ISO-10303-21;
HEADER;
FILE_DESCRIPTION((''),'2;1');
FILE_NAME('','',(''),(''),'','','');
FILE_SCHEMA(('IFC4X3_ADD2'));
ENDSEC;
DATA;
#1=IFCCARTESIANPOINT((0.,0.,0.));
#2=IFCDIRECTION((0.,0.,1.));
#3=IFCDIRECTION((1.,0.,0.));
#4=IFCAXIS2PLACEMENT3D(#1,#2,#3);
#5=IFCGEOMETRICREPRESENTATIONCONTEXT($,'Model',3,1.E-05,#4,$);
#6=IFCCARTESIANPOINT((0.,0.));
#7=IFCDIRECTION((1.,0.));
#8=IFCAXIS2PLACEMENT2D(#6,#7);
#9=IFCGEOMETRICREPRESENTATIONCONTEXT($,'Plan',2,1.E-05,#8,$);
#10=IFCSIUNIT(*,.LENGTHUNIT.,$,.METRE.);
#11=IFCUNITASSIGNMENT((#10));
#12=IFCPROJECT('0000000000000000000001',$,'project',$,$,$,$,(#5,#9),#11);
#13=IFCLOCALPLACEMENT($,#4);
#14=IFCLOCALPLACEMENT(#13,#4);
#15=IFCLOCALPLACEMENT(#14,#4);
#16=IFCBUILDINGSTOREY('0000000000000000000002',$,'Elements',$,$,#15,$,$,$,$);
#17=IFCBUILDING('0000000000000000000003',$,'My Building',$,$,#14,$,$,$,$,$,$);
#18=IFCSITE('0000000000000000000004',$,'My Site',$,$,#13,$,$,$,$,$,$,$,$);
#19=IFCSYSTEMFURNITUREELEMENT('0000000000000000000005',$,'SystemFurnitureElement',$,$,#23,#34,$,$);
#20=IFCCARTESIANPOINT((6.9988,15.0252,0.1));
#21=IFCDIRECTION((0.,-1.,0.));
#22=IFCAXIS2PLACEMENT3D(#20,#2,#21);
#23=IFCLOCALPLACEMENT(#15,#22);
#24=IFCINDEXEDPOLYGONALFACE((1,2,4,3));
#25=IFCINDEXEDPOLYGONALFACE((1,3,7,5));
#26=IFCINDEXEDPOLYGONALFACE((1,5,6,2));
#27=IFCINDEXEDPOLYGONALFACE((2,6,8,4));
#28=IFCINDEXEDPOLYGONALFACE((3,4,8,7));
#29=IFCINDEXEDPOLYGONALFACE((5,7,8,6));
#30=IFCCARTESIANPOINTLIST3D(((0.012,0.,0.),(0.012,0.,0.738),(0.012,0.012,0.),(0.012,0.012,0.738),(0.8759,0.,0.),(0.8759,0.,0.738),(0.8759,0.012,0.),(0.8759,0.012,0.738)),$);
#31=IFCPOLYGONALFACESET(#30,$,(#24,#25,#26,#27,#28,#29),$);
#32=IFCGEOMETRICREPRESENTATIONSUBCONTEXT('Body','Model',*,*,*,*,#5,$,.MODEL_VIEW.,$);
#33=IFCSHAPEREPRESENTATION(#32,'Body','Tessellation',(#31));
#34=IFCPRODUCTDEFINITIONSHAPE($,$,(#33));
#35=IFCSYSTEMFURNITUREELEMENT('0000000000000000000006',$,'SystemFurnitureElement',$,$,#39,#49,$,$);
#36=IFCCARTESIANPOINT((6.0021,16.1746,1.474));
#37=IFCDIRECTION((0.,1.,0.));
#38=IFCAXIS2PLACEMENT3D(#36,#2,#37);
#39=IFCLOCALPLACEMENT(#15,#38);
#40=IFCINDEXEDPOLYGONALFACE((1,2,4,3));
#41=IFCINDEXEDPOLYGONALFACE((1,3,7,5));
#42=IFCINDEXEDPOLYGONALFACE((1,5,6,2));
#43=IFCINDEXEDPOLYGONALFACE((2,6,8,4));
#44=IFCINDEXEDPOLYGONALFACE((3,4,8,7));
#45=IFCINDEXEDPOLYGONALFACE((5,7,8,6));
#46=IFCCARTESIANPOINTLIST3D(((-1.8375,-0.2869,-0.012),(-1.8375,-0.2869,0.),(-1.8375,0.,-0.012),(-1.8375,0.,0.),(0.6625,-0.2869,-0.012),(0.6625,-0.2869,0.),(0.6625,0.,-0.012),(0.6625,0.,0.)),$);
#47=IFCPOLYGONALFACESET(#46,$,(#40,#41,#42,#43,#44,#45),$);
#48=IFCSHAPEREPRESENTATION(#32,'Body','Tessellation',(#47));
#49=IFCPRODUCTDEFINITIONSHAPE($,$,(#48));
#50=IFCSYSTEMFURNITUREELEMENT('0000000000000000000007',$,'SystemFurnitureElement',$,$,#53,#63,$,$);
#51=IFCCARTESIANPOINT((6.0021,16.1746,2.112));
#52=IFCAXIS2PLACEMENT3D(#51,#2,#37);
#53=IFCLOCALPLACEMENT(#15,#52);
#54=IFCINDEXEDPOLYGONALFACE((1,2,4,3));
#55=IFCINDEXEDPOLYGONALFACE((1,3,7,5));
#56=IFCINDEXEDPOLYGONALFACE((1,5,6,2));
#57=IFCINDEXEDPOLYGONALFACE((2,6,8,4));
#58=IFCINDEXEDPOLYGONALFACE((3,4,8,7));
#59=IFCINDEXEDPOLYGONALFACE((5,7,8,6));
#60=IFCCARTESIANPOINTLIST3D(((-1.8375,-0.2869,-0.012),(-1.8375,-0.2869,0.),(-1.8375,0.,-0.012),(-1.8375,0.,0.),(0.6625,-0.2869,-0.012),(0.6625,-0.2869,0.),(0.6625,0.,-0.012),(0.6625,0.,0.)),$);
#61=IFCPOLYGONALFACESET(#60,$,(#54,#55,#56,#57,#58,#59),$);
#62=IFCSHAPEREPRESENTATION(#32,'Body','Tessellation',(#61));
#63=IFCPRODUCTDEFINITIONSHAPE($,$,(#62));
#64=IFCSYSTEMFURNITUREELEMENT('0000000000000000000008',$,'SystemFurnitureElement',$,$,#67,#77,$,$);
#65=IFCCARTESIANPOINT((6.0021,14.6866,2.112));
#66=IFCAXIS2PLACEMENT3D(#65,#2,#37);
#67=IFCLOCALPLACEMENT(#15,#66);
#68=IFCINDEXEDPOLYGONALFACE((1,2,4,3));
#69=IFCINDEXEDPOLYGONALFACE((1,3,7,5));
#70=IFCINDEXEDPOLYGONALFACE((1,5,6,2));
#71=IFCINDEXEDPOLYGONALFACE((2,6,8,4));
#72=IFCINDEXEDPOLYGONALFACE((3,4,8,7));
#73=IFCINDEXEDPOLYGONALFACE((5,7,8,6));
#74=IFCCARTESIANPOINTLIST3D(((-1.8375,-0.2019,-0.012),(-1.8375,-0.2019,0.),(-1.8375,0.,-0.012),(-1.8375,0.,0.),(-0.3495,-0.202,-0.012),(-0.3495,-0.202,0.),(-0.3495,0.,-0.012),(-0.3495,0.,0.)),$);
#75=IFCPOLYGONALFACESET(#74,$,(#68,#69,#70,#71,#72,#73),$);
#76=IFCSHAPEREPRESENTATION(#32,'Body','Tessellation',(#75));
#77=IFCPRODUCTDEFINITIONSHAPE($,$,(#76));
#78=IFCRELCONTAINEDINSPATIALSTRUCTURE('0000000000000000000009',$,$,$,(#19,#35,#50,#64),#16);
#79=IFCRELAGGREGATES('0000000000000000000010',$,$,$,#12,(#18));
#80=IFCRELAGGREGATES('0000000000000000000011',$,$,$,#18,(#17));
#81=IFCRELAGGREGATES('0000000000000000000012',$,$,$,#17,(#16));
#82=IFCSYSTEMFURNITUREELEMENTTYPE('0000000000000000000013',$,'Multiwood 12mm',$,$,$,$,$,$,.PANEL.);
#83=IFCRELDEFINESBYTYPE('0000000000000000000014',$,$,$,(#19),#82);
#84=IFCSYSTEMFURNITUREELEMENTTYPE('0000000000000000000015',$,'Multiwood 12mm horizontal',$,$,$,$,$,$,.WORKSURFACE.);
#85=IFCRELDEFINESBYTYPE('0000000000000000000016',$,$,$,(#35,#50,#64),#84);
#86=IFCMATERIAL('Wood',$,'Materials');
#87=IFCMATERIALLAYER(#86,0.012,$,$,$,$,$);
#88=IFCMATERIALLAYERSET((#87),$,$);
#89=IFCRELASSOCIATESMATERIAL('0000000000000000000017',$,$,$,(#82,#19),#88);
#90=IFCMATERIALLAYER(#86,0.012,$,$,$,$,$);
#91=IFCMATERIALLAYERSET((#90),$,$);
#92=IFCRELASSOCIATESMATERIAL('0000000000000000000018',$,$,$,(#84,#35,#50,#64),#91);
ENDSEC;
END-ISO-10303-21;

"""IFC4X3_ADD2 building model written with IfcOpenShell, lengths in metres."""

from ifc_helpers import new_model, si_unit, frame, origin_with_axes, origin_2d_with_axis, place, context, subcontext, project, spatial, line, indexed_curve, outline, extrude, material, layer, layer_set, layer_usage, type_object, element, save


model = new_model("IFC4X3_ADD2")

# Units and contexts
model_context = context("Model", 3, precision=1e-05, world=origin_with_axes())
plan_context = context("Plan", 2, precision=1e-05, world=origin_2d_with_axis())
body_context = subcontext(model_context, "Body", "Model", "MODEL_VIEW")
ifc_project = project(units=[si_unit("LENGTHUNIT", "METRE")], contexts=[model_context, plan_context])

# Site, building, storey
site_placement = place(None, origin_with_axes())
site = spatial("IfcSite", under=ifc_project, at=site_placement, Name="My Site")
building_placement = place(site_placement, origin_with_axes())
building = spatial("IfcBuilding", under=site, at=building_placement, Name="My Building")
storey_placement = place(building_placement, origin_with_axes())
storey = spatial("IfcBuildingStorey", under=building, at=storey_placement, Name="Elements")

# Shared definitions
ifc_material_1 = material(Name="Wood", Category="Materials")
ifc_layer_1 = layer(ifc_material_1, 0.012)
ifc_layer_set_1 = layer_set([ifc_layer_1])
system_furniture_element_type_1 = type_object("IfcSystemFurnitureElementType", Name="Multiwood 12mm", PredefinedType="PANEL", material=ifc_layer_set_1)

# System furniture elements
ifc_layer_usage_1 = layer_usage(ifc_layer_set_1, "AXIS2", "POSITIVE", 0.0)
system_furniture_element_1_placement = place(storey_placement, frame((6.9988, 15.0252, 0.1), z_axis=(0.0, 0.0, 1.0), x_axis=(0.0, -1.0, 0.0)))
element("IfcSystemFurnitureElement", 1, at=system_furniture_element_1_placement, inside=storey, type_object=system_furniture_element_type_1, material=ifc_layer_usage_1, Name="SystemFurnitureElement", context=body_context, shape_type="SweptSolid", body=[
    extrude(outline(indexed_curve([(0.012, 0.0), (0.012, 0.012), (0.8759, 0.012), (0.8759, 0.0)], segments=[line(1, 2, 3, 4, 1)])), origin_with_axes(), (0.0, 0.0, 1.0), 0.738),
])
ifc_layer_2 = layer(ifc_material_1, 0.012)
ifc_layer_set_2 = layer_set([ifc_layer_2])
ifc_layer_usage_2 = layer_usage(ifc_layer_set_2, "AXIS3", "POSITIVE", -0.012)
system_furniture_element_type_2 = type_object("IfcSystemFurnitureElementType", Name="Multiwood 12mm horizontal", PredefinedType="WORKSURFACE", material=ifc_layer_set_2)
system_furniture_element_2_placement = place(storey_placement, frame((6.0021, 16.1746, 1.474), z_axis=(0.0, 0.0, 1.0), x_axis=(0.0, 1.0, 0.0)))
element("IfcSystemFurnitureElement", 2, at=system_furniture_element_2_placement, inside=storey, type_object=system_furniture_element_type_2, material=ifc_layer_usage_2, Name="SystemFurnitureElement", context=body_context, shape_type="SweptSolid", body=[
    extrude(outline(indexed_curve([(-1.8375, -0.2869), (0.6625, -0.2869), (0.6625, 0.0), (-1.8375, 0.0), (-1.8375, -0.2869)])), frame((0.0, 0.0, -0.012), z_axis=(0.0, 0.0, 1.0), x_axis=(1.0, 0.0, 0.0)), (0.0, 0.0, 1.0), 0.012),
])
ifc_layer_usage_3 = layer_usage(ifc_layer_set_2, "AXIS3", "POSITIVE", -0.012)
system_furniture_element_3_placement = place(storey_placement, frame((6.0021, 16.1746, 2.112), z_axis=(0.0, 0.0, 1.0), x_axis=(0.0, 1.0, 0.0)))
element("IfcSystemFurnitureElement", 3, at=system_furniture_element_3_placement, inside=storey, type_object=system_furniture_element_type_2, material=ifc_layer_usage_3, Name="SystemFurnitureElement", context=body_context, shape_type="SweptSolid", body=[
    extrude(outline(indexed_curve([(-1.8375, -0.2869), (0.6625, -0.2869), (0.6625, 0.0), (-1.8375, 0.0), (-1.8375, -0.2869)])), frame((0.0, 0.0, -0.012), z_axis=(0.0, 0.0, 1.0), x_axis=(1.0, 0.0, 0.0)), (0.0, 0.0, 1.0), 0.012),
])
ifc_layer_usage_4 = layer_usage(ifc_layer_set_2, "AXIS3", "POSITIVE", -0.012)
system_furniture_element_4_placement = place(storey_placement, frame((6.0021, 14.6866, 2.112), z_axis=(0.0, 0.0, 1.0), x_axis=(0.0, 1.0, 0.0)))
element("IfcSystemFurnitureElement", 4, at=system_furniture_element_4_placement, inside=storey, type_object=system_furniture_element_type_2, material=ifc_layer_usage_4, Name="SystemFurnitureElement", context=body_context, shape_type="SweptSolid", body=[
    extrude(outline(indexed_curve([(-1.8375, -0.2019), (-0.3495, -0.202), (-0.3495, 0.0), (-1.8375, 0.0), (-1.8375, -0.2019)])), frame((0.0, 0.0, -0.012), z_axis=(0.0, 0.0, 1.0), x_axis=(1.0, 0.0, 0.0)), (0.0, 0.0, 1.0), 0.012),
])

save(model, "model.ifc")
